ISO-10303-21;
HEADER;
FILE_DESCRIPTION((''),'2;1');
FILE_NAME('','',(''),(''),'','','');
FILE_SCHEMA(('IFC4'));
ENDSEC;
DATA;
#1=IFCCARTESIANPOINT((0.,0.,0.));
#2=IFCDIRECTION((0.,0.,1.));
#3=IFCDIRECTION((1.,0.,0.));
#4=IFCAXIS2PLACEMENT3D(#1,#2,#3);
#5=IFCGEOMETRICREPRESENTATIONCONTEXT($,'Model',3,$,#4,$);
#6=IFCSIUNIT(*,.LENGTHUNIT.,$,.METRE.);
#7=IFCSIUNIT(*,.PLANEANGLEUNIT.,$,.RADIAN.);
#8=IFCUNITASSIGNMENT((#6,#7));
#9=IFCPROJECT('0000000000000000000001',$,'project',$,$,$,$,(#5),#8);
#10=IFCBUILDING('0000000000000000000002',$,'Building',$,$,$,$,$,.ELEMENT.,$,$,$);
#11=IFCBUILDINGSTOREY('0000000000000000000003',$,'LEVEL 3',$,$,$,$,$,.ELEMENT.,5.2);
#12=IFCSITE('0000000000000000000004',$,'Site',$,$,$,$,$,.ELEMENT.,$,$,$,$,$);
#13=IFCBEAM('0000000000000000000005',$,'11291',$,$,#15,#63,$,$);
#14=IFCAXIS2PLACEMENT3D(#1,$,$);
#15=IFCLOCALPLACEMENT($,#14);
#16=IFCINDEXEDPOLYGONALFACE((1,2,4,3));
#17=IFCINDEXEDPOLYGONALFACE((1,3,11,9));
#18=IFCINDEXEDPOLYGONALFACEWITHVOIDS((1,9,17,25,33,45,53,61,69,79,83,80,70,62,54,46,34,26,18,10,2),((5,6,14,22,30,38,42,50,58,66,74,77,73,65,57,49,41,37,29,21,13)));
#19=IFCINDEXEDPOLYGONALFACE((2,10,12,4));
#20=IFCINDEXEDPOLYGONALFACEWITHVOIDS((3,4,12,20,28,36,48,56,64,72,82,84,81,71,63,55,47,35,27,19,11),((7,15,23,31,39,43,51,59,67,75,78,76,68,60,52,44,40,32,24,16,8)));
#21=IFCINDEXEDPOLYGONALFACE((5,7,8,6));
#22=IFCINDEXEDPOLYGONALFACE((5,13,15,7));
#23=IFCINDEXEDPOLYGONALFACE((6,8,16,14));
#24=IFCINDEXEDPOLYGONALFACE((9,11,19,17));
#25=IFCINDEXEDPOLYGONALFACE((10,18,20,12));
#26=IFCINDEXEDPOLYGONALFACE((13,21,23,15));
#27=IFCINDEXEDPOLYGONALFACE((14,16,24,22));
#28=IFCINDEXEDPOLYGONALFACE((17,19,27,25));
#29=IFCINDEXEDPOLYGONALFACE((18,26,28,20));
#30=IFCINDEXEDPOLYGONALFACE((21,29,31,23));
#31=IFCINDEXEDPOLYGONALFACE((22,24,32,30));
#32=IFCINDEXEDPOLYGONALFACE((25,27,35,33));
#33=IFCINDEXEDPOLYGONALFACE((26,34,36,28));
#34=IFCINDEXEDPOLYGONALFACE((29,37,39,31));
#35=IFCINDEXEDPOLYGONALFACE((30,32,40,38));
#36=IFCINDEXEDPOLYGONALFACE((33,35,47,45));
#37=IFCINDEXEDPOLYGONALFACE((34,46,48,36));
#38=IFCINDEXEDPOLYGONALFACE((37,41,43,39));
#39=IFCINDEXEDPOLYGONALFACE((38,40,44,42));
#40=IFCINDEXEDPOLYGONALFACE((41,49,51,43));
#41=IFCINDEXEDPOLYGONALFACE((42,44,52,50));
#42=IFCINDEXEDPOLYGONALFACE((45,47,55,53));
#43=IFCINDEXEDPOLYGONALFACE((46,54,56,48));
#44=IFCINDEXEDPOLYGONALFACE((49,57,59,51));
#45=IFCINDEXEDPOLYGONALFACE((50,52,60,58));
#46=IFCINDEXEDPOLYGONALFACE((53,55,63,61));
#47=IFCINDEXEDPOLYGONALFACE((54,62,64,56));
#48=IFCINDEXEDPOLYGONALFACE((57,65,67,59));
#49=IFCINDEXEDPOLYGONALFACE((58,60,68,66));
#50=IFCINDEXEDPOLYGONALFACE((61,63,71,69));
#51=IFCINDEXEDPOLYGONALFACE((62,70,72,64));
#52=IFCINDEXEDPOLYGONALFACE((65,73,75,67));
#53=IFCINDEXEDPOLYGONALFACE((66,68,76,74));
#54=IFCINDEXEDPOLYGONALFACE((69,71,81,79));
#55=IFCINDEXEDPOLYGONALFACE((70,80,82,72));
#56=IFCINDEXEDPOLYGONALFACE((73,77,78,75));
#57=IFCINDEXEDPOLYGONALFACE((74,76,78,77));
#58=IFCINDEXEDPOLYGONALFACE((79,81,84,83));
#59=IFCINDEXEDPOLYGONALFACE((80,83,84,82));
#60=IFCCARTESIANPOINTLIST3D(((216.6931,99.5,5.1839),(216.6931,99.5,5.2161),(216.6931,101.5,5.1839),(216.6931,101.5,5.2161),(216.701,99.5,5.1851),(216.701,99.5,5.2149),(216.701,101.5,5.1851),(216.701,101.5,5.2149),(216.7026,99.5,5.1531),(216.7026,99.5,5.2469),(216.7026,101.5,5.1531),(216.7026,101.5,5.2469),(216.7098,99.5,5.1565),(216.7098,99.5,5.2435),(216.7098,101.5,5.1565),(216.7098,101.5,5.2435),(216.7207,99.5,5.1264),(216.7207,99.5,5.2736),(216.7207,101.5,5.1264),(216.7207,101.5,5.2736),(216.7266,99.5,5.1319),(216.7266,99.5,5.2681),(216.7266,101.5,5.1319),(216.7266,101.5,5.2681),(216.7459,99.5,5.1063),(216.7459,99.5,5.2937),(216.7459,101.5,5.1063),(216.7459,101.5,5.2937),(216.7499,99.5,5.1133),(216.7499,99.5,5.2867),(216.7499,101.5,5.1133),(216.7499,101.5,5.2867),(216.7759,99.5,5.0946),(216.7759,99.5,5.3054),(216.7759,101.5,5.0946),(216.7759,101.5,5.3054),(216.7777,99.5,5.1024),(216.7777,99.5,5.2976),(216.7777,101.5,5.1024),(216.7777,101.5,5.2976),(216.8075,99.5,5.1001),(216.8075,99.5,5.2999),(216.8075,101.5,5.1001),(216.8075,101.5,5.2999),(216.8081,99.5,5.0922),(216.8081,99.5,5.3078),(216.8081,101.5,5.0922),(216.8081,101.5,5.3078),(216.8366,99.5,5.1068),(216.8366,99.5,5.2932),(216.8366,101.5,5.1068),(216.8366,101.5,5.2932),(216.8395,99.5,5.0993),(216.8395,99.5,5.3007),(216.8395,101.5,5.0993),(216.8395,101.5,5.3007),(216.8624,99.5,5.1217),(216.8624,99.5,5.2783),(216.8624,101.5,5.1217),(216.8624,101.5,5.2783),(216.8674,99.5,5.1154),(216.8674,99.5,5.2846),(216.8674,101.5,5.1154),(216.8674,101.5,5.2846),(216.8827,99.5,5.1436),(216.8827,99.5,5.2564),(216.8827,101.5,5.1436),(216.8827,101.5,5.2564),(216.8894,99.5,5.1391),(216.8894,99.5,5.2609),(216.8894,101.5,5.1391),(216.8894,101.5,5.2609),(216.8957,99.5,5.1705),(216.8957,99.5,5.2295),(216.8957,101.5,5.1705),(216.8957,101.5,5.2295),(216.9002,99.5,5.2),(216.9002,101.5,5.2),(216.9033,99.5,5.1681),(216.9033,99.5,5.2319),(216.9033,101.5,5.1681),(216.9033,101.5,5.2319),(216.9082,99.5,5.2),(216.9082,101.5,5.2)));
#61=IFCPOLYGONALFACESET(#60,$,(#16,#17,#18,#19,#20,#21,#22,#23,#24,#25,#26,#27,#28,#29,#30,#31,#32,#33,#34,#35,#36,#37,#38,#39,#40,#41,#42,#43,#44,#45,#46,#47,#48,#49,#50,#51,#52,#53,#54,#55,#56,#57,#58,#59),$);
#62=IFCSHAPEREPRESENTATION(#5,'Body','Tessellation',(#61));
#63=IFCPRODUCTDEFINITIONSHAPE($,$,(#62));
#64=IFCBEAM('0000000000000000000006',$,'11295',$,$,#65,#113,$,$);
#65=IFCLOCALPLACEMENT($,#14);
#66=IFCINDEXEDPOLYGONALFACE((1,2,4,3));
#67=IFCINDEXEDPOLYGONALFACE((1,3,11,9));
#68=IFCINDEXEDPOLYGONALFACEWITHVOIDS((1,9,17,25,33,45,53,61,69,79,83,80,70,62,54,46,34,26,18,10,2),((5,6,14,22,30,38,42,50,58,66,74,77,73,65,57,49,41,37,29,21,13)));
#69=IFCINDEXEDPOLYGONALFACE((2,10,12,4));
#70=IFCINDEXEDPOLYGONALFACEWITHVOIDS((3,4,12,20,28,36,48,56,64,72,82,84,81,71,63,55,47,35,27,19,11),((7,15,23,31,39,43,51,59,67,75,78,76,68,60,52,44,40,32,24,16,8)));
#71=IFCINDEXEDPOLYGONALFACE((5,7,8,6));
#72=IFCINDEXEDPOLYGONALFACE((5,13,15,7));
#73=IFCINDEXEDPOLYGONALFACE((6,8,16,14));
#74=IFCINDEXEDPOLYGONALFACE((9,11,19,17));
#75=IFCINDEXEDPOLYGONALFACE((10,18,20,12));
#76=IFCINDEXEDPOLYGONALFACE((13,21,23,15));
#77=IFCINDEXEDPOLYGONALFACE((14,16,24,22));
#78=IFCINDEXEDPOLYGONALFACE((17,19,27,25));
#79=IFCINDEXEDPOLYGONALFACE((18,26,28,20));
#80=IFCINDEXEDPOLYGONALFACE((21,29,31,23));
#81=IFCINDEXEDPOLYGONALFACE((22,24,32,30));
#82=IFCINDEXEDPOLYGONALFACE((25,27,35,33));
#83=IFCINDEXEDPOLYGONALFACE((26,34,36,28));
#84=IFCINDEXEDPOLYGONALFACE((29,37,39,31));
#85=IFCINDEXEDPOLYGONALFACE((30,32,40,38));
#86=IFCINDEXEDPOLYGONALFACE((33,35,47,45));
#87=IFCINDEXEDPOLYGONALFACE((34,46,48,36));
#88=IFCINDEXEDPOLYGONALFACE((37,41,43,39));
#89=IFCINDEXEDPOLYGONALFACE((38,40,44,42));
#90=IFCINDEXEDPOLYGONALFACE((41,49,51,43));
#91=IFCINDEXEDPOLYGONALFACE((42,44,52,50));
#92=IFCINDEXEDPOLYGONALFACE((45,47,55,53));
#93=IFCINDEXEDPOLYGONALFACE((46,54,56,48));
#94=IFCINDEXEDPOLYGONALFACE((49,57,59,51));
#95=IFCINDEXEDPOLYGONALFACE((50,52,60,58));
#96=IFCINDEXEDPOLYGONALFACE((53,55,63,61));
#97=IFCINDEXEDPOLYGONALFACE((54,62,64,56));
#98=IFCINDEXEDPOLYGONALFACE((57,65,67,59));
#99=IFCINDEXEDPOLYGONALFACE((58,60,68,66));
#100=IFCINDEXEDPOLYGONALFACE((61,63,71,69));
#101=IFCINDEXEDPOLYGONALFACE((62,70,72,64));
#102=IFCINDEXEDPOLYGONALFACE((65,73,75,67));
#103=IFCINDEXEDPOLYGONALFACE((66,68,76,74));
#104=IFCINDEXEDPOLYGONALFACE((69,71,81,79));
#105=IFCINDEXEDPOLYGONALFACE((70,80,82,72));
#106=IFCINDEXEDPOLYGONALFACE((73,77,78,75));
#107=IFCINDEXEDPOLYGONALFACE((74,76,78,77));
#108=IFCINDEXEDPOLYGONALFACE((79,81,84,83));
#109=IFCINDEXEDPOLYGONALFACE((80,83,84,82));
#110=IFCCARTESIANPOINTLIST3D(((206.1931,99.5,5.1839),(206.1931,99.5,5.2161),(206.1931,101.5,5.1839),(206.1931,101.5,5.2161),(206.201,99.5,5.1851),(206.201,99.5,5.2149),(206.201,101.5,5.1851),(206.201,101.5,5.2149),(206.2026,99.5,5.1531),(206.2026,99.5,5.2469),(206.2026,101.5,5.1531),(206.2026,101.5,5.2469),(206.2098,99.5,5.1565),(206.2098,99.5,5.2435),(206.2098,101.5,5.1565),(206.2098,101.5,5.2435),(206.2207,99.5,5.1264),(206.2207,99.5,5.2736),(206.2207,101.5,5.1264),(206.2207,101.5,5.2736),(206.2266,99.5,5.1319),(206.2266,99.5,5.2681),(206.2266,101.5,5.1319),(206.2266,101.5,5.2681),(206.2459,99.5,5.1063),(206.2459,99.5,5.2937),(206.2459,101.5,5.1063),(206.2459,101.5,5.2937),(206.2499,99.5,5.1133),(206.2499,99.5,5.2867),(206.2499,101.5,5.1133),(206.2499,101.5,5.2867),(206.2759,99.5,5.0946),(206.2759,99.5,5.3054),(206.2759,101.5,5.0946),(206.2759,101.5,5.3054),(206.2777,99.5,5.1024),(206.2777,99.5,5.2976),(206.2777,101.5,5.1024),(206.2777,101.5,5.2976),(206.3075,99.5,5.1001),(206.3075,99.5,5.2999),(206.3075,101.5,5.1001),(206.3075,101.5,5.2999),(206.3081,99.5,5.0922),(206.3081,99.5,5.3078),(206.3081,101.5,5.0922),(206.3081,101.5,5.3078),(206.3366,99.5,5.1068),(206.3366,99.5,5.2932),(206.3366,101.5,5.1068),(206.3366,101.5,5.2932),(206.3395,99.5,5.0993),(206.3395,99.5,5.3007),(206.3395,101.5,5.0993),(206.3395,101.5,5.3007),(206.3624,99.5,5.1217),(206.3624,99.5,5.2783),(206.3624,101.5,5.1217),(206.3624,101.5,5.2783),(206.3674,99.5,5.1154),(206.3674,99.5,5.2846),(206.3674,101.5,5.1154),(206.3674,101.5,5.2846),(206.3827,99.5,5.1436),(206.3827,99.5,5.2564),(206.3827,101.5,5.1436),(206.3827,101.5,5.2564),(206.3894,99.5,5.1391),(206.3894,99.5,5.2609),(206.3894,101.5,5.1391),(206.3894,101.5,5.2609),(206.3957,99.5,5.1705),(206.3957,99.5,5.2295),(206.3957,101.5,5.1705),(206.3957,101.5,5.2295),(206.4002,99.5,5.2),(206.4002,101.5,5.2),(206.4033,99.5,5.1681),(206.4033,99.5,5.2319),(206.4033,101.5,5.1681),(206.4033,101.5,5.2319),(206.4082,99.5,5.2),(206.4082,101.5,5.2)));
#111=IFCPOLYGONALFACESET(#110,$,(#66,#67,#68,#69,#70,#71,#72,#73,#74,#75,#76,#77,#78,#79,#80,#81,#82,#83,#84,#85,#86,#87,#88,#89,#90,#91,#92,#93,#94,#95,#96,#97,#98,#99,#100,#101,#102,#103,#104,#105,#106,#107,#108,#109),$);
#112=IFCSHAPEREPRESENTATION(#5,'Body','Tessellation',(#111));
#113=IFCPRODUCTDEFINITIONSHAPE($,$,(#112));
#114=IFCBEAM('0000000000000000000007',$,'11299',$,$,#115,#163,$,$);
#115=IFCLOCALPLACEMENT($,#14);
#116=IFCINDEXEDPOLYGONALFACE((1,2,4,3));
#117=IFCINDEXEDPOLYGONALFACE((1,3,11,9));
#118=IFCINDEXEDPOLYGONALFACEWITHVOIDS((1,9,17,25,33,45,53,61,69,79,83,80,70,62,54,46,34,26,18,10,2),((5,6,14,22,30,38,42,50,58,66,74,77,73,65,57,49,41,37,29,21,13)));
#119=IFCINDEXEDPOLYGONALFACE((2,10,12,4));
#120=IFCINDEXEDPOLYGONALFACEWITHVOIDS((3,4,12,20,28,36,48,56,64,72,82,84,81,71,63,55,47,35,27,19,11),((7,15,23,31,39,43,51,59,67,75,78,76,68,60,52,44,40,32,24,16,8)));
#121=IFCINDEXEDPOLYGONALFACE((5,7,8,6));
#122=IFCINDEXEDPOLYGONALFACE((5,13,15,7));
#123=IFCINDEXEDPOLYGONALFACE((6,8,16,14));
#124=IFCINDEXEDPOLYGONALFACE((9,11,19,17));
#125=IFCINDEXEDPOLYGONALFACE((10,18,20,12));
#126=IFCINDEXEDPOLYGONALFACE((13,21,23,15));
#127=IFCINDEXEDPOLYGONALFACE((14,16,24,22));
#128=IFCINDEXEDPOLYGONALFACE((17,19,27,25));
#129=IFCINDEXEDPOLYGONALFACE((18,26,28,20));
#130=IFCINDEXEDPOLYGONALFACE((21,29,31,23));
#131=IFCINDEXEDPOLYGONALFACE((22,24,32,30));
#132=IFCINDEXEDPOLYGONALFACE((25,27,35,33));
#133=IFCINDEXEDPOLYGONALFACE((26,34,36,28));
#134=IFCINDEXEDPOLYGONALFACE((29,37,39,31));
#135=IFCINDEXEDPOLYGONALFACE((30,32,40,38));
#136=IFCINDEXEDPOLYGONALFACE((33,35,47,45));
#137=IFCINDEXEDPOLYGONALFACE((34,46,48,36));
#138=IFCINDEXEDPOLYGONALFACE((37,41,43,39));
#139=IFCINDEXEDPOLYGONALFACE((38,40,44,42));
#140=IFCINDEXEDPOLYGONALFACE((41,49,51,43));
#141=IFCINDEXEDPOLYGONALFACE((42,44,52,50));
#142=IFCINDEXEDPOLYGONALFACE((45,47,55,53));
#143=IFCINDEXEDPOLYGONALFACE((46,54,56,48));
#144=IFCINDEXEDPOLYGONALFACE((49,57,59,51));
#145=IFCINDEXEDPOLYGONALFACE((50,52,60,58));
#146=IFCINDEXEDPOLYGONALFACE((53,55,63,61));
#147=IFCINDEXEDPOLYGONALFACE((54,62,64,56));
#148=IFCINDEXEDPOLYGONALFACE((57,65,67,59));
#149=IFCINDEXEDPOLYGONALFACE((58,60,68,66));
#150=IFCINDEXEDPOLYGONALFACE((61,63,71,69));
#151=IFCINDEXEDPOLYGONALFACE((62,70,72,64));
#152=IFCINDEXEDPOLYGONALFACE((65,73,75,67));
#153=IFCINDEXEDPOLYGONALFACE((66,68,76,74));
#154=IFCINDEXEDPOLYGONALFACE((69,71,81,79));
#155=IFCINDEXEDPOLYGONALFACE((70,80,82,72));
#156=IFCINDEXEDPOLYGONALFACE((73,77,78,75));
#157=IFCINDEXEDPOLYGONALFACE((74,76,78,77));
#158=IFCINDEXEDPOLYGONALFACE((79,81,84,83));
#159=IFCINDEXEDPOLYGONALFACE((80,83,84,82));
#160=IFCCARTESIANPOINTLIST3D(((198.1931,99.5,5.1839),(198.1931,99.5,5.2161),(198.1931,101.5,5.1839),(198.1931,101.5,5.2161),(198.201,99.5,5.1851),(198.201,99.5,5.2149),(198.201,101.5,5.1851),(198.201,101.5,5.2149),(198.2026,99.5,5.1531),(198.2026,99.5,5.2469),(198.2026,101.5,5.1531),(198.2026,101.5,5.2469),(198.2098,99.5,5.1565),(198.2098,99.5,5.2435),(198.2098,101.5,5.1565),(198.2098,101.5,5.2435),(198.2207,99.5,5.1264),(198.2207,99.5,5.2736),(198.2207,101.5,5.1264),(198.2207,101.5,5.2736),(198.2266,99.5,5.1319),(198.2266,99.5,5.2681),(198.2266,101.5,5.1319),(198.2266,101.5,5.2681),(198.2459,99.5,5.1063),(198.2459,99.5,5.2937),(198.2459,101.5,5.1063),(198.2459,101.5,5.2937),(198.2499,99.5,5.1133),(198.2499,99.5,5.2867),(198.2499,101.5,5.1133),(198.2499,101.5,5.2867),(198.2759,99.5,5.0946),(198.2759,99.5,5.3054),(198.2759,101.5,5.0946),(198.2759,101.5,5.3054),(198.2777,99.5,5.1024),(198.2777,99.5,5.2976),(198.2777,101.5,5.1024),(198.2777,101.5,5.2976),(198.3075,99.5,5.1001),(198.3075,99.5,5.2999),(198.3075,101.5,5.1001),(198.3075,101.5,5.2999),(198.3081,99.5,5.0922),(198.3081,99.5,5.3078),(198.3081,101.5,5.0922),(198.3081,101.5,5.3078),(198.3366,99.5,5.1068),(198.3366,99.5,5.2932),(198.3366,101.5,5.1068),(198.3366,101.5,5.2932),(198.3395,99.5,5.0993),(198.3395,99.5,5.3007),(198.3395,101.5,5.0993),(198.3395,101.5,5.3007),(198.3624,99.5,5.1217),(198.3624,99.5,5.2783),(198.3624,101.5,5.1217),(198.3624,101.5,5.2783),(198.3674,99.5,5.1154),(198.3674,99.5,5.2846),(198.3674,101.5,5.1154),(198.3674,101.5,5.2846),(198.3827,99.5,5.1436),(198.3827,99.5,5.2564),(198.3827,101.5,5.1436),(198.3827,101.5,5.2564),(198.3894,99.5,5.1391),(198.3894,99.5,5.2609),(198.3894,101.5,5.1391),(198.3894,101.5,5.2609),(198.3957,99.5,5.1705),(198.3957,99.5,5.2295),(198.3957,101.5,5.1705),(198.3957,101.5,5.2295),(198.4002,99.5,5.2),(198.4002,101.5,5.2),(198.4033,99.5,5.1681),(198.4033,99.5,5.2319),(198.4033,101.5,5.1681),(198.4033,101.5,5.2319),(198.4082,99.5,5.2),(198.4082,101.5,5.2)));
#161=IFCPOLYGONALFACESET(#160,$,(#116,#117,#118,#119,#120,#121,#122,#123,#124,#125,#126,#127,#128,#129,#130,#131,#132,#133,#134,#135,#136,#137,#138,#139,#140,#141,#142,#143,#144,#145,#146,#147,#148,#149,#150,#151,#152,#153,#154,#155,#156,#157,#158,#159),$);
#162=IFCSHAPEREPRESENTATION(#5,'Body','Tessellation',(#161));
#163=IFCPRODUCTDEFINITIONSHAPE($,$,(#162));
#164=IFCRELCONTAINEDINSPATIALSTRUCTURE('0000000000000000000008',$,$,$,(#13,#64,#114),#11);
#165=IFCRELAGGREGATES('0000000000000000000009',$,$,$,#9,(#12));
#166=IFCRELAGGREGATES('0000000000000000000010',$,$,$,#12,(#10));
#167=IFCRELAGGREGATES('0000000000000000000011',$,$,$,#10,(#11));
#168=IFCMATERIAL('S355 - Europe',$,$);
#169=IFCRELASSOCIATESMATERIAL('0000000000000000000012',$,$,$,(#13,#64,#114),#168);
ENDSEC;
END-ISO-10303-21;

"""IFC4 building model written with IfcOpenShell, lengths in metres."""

from ifc_helpers import new_model, si_unit, frame, origin_with_axes, origin_2d_with_axis, place, context, project, spatial, hollow_circle, extrude, material, material_profile, profile_set, profile_usage, element, save


model = new_model("IFC4")

# Units and contexts
model_context = context("Model", 3, world=origin_with_axes())
ifc_project = project(units=[si_unit("LENGTHUNIT", "METRE"), si_unit("PLANEANGLEUNIT", "RADIAN")], contexts=[model_context])

# Site, building, storey
site = spatial("IfcSite", under=ifc_project, Name="Site", CompositionType="ELEMENT")
building = spatial("IfcBuilding", under=site, Name="Building", CompositionType="ELEMENT")
storey = spatial("IfcBuildingStorey", under=building, Name="LEVEL 3", CompositionType="ELEMENT", Elevation=5.2)

# Shared definitions
ifc_material = material(Name="S355 - Europe")

# Beams
ifc_material_profile_1 = material_profile(ifc_material, hollow_circle(Radius=0.1081, WallThickness=0.008, at=origin_2d_with_axis()))
ifc_profile_set_1 = profile_set([ifc_material_profile_1])
ifc_profile_usage_1 = profile_usage(ifc_profile_set_1, cardinal=10)
beam_1_placement = place(None, frame((216.8, 101.5, 5.2), z_axis=(0.0, -1.0, 0.0), x_axis=(1.0, 0.0, 0.0)))
element("IfcBeam", 1, at=beam_1_placement, inside=storey, material=ifc_profile_usage_1, Name="11291", context=model_context, shape_type="SweptSolid", body=[
    extrude(hollow_circle(Radius=0.1081, WallThickness=0.008, at=origin_2d_with_axis()), origin_with_axes(), (0.0, 0.0, 1.0), 2.0),
])
ifc_material_profile_2 = material_profile(ifc_material, hollow_circle(Radius=0.1081, WallThickness=0.008, at=origin_2d_with_axis()))
ifc_profile_set_2 = profile_set([ifc_material_profile_2])
ifc_profile_usage_2 = profile_usage(ifc_profile_set_2, cardinal=10)
beam_2_placement = place(None, frame((206.3, 101.5, 5.2), z_axis=(0.0, -1.0, 0.0), x_axis=(1.0, 0.0, 0.0)))
element("IfcBeam", 2, at=beam_2_placement, inside=storey, material=ifc_profile_usage_2, Name="11295", context=model_context, shape_type="SweptSolid", body=[
    extrude(hollow_circle(Radius=0.1081, WallThickness=0.008, at=origin_2d_with_axis()), origin_with_axes(), (0.0, 0.0, 1.0), 2.0),
])
ifc_material_profile_3 = material_profile(ifc_material, hollow_circle(Radius=0.1081, WallThickness=0.008, at=origin_2d_with_axis()))
ifc_profile_set_3 = profile_set([ifc_material_profile_3])
ifc_profile_usage_3 = profile_usage(ifc_profile_set_3, cardinal=10)
beam_3_placement = place(None, frame((198.3, 101.5, 5.2), z_axis=(0.0, -1.0, 0.0), x_axis=(1.0, 0.0, 0.0)))
element("IfcBeam", 3, at=beam_3_placement, inside=storey, material=ifc_profile_usage_3, Name="11299", context=model_context, shape_type="SweptSolid", body=[
    extrude(hollow_circle(Radius=0.1081, WallThickness=0.008, at=origin_2d_with_axis()), origin_with_axes(), (0.0, 0.0, 1.0), 2.0),
])

save(model, "model.ifc")
